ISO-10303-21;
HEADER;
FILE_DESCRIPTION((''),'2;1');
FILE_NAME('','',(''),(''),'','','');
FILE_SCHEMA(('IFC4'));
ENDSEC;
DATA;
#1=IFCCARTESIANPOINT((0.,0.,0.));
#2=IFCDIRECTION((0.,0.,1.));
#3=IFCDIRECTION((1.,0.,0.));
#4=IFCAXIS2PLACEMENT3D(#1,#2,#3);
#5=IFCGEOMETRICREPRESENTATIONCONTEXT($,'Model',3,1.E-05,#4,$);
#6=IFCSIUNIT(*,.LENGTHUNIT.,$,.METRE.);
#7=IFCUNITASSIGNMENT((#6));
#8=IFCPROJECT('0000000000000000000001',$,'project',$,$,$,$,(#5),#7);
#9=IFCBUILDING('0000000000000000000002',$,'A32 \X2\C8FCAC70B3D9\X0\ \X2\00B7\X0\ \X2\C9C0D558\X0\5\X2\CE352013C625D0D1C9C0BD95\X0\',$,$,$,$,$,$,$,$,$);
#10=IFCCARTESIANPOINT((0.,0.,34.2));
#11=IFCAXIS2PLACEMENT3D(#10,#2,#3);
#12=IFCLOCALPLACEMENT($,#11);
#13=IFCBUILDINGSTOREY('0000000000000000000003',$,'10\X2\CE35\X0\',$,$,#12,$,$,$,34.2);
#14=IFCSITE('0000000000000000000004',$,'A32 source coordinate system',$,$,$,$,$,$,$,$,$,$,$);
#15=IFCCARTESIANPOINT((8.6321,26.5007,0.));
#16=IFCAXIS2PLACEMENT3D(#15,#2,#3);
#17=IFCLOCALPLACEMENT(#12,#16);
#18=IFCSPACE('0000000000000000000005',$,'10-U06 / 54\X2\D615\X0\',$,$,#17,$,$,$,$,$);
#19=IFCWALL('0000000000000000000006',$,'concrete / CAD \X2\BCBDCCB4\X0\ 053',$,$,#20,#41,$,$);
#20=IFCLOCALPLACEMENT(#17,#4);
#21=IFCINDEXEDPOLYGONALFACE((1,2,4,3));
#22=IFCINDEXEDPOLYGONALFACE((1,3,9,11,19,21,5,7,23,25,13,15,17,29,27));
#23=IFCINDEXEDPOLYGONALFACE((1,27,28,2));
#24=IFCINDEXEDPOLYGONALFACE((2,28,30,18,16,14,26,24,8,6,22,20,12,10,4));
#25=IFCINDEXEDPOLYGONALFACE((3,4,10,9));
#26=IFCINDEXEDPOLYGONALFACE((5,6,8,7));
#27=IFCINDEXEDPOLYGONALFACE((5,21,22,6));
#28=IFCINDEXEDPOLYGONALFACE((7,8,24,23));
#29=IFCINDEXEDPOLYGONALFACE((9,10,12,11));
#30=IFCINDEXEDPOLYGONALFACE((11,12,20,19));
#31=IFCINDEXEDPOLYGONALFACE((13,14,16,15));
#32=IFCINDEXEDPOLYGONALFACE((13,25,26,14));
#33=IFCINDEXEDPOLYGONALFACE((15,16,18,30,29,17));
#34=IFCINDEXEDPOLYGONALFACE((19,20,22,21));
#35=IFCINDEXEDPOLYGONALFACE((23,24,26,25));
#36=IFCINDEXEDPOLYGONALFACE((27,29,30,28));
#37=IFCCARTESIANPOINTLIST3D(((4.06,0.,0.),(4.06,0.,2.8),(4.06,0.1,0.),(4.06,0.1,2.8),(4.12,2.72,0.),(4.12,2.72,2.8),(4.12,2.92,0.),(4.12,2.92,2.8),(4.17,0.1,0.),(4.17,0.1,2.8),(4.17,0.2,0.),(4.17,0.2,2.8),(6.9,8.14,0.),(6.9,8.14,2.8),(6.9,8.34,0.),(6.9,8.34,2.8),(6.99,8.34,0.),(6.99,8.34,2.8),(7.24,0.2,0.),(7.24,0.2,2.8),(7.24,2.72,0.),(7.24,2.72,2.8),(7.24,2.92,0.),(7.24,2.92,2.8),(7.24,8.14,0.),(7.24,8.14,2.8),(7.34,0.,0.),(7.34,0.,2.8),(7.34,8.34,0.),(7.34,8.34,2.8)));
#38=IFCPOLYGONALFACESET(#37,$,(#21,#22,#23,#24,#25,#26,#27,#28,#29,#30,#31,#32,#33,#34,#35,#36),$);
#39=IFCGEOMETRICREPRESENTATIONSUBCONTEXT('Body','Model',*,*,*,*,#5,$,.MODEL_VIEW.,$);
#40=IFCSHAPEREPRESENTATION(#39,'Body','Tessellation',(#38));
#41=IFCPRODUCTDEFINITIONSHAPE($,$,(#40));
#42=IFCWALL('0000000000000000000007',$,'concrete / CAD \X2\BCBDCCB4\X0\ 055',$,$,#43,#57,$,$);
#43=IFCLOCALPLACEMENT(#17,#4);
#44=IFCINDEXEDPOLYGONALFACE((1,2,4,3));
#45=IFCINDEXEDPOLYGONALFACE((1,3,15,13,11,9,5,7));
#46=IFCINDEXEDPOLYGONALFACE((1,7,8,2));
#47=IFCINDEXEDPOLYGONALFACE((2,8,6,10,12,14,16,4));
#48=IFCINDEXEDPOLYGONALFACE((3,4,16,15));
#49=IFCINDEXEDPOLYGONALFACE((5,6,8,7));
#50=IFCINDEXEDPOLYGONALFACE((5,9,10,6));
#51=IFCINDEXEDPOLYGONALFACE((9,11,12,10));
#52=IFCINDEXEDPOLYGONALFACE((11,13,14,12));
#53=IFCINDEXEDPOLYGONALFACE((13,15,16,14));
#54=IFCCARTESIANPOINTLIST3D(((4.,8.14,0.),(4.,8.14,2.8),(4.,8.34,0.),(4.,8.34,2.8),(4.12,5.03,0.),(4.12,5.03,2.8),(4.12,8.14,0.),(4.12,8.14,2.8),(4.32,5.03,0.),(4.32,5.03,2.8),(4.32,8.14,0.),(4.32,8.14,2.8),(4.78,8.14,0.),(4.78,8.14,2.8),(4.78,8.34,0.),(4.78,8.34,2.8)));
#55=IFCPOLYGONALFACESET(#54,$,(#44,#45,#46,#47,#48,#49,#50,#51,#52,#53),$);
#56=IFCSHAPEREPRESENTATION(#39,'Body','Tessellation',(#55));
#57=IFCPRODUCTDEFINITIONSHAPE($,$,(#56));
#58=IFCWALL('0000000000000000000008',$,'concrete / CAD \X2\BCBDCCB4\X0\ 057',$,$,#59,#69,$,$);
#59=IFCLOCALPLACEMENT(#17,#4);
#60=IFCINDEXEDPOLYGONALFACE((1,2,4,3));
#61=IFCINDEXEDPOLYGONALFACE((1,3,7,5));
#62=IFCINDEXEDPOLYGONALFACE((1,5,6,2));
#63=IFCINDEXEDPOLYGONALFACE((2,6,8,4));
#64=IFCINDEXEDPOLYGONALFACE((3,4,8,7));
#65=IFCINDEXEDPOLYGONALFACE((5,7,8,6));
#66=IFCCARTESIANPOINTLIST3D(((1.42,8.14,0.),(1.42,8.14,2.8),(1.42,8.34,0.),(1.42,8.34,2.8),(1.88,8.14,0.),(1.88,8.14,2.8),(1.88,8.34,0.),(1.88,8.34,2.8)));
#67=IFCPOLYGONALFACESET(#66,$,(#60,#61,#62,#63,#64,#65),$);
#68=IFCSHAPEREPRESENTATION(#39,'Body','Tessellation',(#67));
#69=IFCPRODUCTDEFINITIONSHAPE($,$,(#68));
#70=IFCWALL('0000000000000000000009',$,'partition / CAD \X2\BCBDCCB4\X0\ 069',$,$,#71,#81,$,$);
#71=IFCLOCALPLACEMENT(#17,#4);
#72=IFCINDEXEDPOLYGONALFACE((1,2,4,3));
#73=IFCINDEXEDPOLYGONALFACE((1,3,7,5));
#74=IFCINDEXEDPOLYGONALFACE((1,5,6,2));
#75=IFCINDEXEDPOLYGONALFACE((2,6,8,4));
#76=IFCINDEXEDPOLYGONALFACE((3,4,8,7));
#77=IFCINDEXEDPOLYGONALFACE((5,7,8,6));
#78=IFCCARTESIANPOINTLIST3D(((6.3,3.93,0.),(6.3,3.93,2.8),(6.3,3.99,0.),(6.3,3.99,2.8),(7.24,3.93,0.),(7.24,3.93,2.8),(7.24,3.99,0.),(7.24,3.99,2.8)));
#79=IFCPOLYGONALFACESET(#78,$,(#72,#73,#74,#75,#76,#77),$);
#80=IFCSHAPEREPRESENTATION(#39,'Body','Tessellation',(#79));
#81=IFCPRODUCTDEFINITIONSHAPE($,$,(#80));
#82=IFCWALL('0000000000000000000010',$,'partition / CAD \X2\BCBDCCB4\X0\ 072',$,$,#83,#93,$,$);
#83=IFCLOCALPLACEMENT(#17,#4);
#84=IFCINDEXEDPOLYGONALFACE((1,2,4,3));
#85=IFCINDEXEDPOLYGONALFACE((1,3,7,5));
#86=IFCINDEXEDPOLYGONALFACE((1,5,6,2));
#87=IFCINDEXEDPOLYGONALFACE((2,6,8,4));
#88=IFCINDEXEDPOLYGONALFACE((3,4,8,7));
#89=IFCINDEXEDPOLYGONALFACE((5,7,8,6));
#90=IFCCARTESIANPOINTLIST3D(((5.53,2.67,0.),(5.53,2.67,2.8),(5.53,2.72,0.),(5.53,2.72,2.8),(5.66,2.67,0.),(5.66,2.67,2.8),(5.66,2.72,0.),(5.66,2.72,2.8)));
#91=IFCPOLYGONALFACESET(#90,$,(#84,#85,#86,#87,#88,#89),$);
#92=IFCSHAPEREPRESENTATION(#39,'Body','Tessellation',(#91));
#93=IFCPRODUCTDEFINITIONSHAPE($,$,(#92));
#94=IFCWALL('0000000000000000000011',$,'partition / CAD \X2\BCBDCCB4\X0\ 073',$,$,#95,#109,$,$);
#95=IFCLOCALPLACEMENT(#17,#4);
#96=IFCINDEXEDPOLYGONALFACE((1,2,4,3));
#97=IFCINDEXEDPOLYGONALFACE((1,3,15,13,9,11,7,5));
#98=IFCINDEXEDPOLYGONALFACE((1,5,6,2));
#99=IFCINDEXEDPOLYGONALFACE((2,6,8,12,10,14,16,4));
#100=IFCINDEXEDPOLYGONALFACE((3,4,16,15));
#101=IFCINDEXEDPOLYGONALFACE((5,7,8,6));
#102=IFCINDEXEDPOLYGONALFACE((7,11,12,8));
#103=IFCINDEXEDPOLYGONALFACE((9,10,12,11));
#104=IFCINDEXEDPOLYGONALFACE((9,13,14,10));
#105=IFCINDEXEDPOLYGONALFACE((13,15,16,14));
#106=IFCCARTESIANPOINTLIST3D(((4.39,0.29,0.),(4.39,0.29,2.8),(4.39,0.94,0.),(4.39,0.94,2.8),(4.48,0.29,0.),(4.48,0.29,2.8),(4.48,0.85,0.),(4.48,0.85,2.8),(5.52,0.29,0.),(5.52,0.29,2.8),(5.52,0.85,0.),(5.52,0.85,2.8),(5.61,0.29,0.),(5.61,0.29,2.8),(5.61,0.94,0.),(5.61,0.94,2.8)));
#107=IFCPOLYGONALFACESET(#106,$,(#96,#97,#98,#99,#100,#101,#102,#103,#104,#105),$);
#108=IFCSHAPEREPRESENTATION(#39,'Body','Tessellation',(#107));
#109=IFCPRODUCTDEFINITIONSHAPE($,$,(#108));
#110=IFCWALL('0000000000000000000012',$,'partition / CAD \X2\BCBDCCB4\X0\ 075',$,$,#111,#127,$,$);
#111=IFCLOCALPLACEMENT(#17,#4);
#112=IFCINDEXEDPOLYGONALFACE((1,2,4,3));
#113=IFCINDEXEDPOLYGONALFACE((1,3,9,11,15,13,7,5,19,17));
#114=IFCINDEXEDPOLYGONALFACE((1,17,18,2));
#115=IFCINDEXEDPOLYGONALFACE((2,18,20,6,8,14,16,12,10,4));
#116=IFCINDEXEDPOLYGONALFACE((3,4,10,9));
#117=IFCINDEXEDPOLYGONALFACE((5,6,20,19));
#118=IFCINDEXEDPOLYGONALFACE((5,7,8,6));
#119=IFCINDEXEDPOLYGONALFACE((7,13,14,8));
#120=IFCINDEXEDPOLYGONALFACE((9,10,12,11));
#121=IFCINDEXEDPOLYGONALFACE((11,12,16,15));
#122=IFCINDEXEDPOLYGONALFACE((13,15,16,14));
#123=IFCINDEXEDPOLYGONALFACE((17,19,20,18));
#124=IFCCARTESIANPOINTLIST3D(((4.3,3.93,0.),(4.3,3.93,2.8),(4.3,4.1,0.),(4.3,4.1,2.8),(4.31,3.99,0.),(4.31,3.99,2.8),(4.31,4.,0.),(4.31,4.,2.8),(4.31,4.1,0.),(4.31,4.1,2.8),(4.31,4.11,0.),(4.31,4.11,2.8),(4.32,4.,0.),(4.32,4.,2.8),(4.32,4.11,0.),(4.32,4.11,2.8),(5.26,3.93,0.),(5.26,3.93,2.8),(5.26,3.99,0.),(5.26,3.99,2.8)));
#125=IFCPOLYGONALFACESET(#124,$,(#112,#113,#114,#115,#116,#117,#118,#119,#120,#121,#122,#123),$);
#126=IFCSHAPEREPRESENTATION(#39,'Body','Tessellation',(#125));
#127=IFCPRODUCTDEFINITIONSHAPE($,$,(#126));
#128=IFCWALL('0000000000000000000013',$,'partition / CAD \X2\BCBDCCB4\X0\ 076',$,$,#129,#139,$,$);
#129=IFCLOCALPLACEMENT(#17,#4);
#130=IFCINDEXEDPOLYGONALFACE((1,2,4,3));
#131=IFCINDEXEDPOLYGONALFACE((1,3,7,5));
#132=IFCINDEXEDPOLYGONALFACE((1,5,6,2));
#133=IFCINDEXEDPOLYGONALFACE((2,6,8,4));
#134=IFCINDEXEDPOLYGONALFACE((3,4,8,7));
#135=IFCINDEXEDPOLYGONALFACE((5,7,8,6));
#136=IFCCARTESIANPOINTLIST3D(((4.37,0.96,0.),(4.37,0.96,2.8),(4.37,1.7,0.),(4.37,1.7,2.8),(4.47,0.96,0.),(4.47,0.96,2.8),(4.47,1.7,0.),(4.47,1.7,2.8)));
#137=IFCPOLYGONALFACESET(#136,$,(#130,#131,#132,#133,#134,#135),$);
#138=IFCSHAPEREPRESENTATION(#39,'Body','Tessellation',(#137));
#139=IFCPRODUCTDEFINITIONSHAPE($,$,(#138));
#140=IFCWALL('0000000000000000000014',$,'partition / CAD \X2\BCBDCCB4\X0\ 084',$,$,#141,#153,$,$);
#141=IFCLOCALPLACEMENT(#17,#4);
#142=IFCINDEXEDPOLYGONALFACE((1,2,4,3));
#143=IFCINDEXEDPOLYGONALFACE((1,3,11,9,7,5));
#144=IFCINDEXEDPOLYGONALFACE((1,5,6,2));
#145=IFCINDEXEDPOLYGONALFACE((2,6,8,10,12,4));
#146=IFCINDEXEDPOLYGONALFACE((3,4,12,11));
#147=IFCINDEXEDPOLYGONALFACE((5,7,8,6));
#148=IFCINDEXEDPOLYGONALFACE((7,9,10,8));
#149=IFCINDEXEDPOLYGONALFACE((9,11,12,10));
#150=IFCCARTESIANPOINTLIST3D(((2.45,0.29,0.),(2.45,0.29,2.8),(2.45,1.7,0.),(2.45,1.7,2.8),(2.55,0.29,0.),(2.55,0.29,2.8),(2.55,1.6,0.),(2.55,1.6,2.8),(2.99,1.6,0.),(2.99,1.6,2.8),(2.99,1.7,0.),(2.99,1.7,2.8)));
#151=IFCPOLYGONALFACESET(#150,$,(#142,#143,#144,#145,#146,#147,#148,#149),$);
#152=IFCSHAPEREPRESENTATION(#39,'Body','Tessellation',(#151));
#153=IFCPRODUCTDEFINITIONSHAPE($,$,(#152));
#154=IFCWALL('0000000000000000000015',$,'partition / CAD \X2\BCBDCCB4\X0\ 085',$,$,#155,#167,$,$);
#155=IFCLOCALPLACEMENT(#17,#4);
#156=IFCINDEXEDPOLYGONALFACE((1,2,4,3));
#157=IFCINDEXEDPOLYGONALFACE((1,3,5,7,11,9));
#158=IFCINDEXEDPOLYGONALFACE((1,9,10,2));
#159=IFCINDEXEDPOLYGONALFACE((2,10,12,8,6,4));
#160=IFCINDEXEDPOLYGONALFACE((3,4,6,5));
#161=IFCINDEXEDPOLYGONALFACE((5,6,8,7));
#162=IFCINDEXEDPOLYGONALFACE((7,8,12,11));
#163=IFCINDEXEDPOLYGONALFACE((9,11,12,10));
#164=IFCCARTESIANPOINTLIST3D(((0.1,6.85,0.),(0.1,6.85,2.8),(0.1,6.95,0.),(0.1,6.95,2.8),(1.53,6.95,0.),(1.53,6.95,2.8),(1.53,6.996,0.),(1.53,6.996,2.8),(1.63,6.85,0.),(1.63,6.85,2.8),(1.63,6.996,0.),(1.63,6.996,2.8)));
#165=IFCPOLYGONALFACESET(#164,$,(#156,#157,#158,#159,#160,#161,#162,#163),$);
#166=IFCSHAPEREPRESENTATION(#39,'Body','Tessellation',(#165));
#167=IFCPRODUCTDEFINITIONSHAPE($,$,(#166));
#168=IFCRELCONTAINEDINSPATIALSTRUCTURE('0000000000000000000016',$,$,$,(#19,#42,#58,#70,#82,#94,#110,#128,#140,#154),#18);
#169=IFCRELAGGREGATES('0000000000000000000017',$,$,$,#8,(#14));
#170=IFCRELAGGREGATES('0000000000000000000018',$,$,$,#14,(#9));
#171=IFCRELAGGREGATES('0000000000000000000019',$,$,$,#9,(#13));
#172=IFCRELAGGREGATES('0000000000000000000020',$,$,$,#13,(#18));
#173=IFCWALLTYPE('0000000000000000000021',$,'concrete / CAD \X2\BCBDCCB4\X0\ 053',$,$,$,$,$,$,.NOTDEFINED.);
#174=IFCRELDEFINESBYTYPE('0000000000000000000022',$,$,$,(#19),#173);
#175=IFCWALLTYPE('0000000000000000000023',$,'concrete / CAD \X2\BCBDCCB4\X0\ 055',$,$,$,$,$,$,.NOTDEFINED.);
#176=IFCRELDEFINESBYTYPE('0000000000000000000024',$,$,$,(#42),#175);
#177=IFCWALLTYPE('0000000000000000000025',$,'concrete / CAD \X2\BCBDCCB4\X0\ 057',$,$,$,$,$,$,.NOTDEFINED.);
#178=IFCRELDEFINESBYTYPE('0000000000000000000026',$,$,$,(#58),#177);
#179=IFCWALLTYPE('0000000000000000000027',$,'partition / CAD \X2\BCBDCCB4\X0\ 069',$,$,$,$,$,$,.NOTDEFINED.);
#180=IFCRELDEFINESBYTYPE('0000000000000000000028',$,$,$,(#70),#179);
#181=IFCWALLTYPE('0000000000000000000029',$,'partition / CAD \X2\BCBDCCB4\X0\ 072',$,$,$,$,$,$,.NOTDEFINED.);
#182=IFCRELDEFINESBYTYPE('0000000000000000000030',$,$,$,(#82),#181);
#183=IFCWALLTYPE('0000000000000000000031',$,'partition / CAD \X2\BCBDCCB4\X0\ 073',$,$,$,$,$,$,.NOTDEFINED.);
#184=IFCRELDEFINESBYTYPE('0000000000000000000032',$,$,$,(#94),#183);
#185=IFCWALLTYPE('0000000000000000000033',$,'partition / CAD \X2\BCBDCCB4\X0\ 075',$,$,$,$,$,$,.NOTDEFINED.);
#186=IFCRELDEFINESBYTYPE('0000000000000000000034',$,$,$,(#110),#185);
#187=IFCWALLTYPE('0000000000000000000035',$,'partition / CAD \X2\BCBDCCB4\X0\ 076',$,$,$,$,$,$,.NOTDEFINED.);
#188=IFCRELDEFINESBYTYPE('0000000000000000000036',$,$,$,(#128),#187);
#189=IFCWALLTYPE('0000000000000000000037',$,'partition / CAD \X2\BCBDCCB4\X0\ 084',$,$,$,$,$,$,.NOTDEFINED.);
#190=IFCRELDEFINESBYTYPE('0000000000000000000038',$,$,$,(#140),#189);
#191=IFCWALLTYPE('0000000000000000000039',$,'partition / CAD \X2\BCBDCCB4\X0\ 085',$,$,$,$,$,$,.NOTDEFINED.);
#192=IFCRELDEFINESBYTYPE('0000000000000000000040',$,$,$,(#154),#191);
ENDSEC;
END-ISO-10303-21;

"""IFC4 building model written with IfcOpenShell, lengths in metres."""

from ifc_helpers import new_model, si_unit, frame, origin, origin_with_axes, place, context, subcontext, project, spatial, polyline, outline, extrude, source, transform, mapped, type_object, type_shapes, element, save


model = new_model("IFC4")

# Units and contexts
model_context = context("Model", 3, precision=1e-05, world=origin_with_axes())
body_context = subcontext(model_context, "Body", "Model", "MODEL_VIEW")
ifc_project = project(units=[si_unit("LENGTHUNIT", "METRE")], contexts=[model_context])

# Site, building, storey, space
site = spatial("IfcSite", under=ifc_project, Name="A32 source coordinate system")
building = spatial("IfcBuilding", under=site, Name="A32 주거동 · 지하5층–옥탑지붕")
storey_placement = place(None, frame((0.0, 0.0, 34.2), z_axis=(0.0, 0.0, 1.0), x_axis=(1.0, 0.0, 0.0)))
storey = spatial("IfcBuildingStorey", under=building, at=storey_placement, Name="10층", Elevation=34.2)
space_placement = place(storey_placement, frame((8.6321, 26.5007, 0.0), z_axis=(0.0, 0.0, 1.0), x_axis=(1.0, 0.0, 0.0)))
space = spatial("IfcSpace", under=storey, at=space_placement, Name="10-U06 / 54형")

# Walls
wall_type_1 = type_object("IfcWallType", Name="concrete / CAD 벽체 053", PredefinedType="NOTDEFINED")
shared_shape_1 = source(origin(), body_context, "Body", "SweptSolid", [
    extrude(outline(polyline([(7.24, 8.14), (6.9, 8.14), (6.9, 8.34), (6.99, 8.34), (6.99, 8.34), (7.34, 8.34), (7.34, 8.34), (7.34, 0.0), (4.06, 0.0), (4.06, 0.1), (4.17, 0.1), (4.17, 0.2), (7.24, 0.2), (7.24, 2.72), (4.12, 2.72), (4.12, 2.92), (7.24, 2.92), (7.24, 8.14)])), origin(), (0.0, 0.0, 1.0), 2.8),
])
type_shapes(wall_type_1, [shared_shape_1])
wall_1_placement = place(space_placement, origin_with_axes())
element("IfcWall", 1, at=wall_1_placement, inside=space, type_object=wall_type_1, Name="concrete / CAD 벽체 053", context=body_context, shape_type="MappedRepresentation", body=[
    mapped(shared_shape_1, transform((0.0, 0.0, 0.0), scale=1.0)),
])
wall_type_2 = type_object("IfcWallType", Name="concrete / CAD 벽체 055", PredefinedType="NOTDEFINED")
shared_shape_2 = source(origin(), body_context, "Body", "SweptSolid", [
    extrude(outline(polyline([(4.32, 5.03), (4.12, 5.03), (4.12, 8.14), (4.0, 8.14), (4.0, 8.34), (4.78, 8.34), (4.78, 8.14), (4.32, 8.14), (4.32, 5.03)])), origin(), (0.0, 0.0, 1.0), 2.8),
])
type_shapes(wall_type_2, [shared_shape_2])
wall_2_placement = place(space_placement, origin_with_axes())
element("IfcWall", 2, at=wall_2_placement, inside=space, type_object=wall_type_2, Name="concrete / CAD 벽체 055", context=body_context, shape_type="MappedRepresentation", body=[
    mapped(shared_shape_2, transform((0.0, 0.0, 0.0), scale=1.0)),
])
wall_type_3 = type_object("IfcWallType", Name="concrete / CAD 벽체 057", PredefinedType="NOTDEFINED")
shared_shape_3 = source(origin(), body_context, "Body", "SweptSolid", [
    extrude(outline(polyline([(1.42, 8.14), (1.42, 8.34), (1.88, 8.34), (1.88, 8.14), (1.42, 8.14)])), origin(), (0.0, 0.0, 1.0), 2.8),
])
type_shapes(wall_type_3, [shared_shape_3])
wall_3_placement = place(space_placement, origin_with_axes())
element("IfcWall", 3, at=wall_3_placement, inside=space, type_object=wall_type_3, Name="concrete / CAD 벽체 057", context=body_context, shape_type="MappedRepresentation", body=[
    mapped(shared_shape_3, transform((0.0, 0.0, 0.0), scale=1.0)),
])
wall_type_4 = type_object("IfcWallType", Name="partition / CAD 벽체 069", PredefinedType="NOTDEFINED")
shared_shape_4 = source(origin(), body_context, "Body", "SweptSolid", [
    extrude(outline(polyline([(7.24, 3.93), (6.3, 3.93), (6.3, 3.99), (7.24, 3.99), (7.24, 3.93)])), origin(), (0.0, 0.0, 1.0), 2.8),
])
type_shapes(wall_type_4, [shared_shape_4])
wall_4_placement = place(space_placement, origin_with_axes())
element("IfcWall", 4, at=wall_4_placement, inside=space, type_object=wall_type_4, Name="partition / CAD 벽체 069", context=body_context, shape_type="MappedRepresentation", body=[
    mapped(shared_shape_4, transform((0.0, 0.0, 0.0), scale=1.0)),
])
wall_type_5 = type_object("IfcWallType", Name="partition / CAD 벽체 072", PredefinedType="NOTDEFINED")
shared_shape_5 = source(origin(), body_context, "Body", "SweptSolid", [
    extrude(outline(polyline([(5.66, 2.67), (5.53, 2.67), (5.53, 2.72), (5.66, 2.72), (5.66, 2.67)])), origin(), (0.0, 0.0, 1.0), 2.8),
])
type_shapes(wall_type_5, [shared_shape_5])
wall_5_placement = place(space_placement, origin_with_axes())
element("IfcWall", 5, at=wall_5_placement, inside=space, type_object=wall_type_5, Name="partition / CAD 벽체 072", context=body_context, shape_type="MappedRepresentation", body=[
    mapped(shared_shape_5, transform((0.0, 0.0, 0.0), scale=1.0)),
])
wall_type_6 = type_object("IfcWallType", Name="partition / CAD 벽체 073", PredefinedType="NOTDEFINED")
shared_shape_6 = source(origin(), body_context, "Body", "SweptSolid", [
    extrude(outline(polyline([(4.48, 0.29), (4.39, 0.29), (4.39, 0.94), (5.61, 0.94), (5.61, 0.29), (5.52, 0.29), (5.52, 0.85), (4.48, 0.85), (4.48, 0.29)])), origin(), (0.0, 0.0, 1.0), 2.8),
])
type_shapes(wall_type_6, [shared_shape_6])
wall_6_placement = place(space_placement, origin_with_axes())
element("IfcWall", 6, at=wall_6_placement, inside=space, type_object=wall_type_6, Name="partition / CAD 벽체 073", context=body_context, shape_type="MappedRepresentation", body=[
    mapped(shared_shape_6, transform((0.0, 0.0, 0.0), scale=1.0)),
])
wall_type_7 = type_object("IfcWallType", Name="partition / CAD 벽체 075", PredefinedType="NOTDEFINED")
shared_shape_7 = source(origin(), body_context, "Body", "SweptSolid", [
    extrude(outline(polyline([(4.32, 4.0), (4.31, 4.0), (4.31, 3.99), (5.26, 3.99), (5.26, 3.93), (4.3, 3.93), (4.3, 4.1), (4.31, 4.1), (4.31, 4.11), (4.32, 4.11), (4.32, 4.0)])), origin(), (0.0, 0.0, 1.0), 2.8),
])
type_shapes(wall_type_7, [shared_shape_7])
wall_7_placement = place(space_placement, origin_with_axes())
element("IfcWall", 7, at=wall_7_placement, inside=space, type_object=wall_type_7, Name="partition / CAD 벽체 075", context=body_context, shape_type="MappedRepresentation", body=[
    mapped(shared_shape_7, transform((0.0, 0.0, 0.0), scale=1.0)),
])
wall_type_8 = type_object("IfcWallType", Name="partition / CAD 벽체 076", PredefinedType="NOTDEFINED")
shared_shape_8 = source(origin(), body_context, "Body", "SweptSolid", [
    extrude(outline(polyline([(4.37, 1.7), (4.47, 1.7), (4.47, 0.96), (4.37, 0.96), (4.37, 1.7)])), origin(), (0.0, 0.0, 1.0), 2.8),
])
type_shapes(wall_type_8, [shared_shape_8])
wall_8_placement = place(space_placement, origin_with_axes())
element("IfcWall", 8, at=wall_8_placement, inside=space, type_object=wall_type_8, Name="partition / CAD 벽체 076", context=body_context, shape_type="MappedRepresentation", body=[
    mapped(shared_shape_8, transform((0.0, 0.0, 0.0), scale=1.0)),
])
wall_type_9 = type_object("IfcWallType", Name="partition / CAD 벽체 084", PredefinedType="NOTDEFINED")
shared_shape_9 = source(origin(), body_context, "Body", "SweptSolid", [
    extrude(outline(polyline([(2.99, 1.6), (2.55, 1.6), (2.55, 0.29), (2.45, 0.29), (2.45, 1.7), (2.99, 1.7), (2.99, 1.6)])), origin(), (0.0, 0.0, 1.0), 2.8),
])
type_shapes(wall_type_9, [shared_shape_9])
wall_9_placement = place(space_placement, origin_with_axes())
element("IfcWall", 9, at=wall_9_placement, inside=space, type_object=wall_type_9, Name="partition / CAD 벽체 084", context=body_context, shape_type="MappedRepresentation", body=[
    mapped(shared_shape_9, transform((0.0, 0.0, 0.0), scale=1.0)),
])
wall_type_10 = type_object("IfcWallType", Name="partition / CAD 벽체 085", PredefinedType="NOTDEFINED")
shared_shape_10 = source(origin(), body_context, "Body", "SweptSolid", [
    extrude(outline(polyline([(1.63, 6.85), (0.1, 6.85), (0.1, 6.95), (1.53, 6.95), (1.53, 6.996), (1.63, 6.996), (1.63, 6.85)])), origin(), (0.0, 0.0, 1.0), 2.8),
])
type_shapes(wall_type_10, [shared_shape_10])
wall_10_placement = place(space_placement, origin_with_axes())
element("IfcWall", 10, at=wall_10_placement, inside=space, type_object=wall_type_10, Name="partition / CAD 벽체 085", context=body_context, shape_type="MappedRepresentation", body=[
    mapped(shared_shape_10, transform((0.0, 0.0, 0.0), scale=1.0)),
])

save(model, "model.ifc")
